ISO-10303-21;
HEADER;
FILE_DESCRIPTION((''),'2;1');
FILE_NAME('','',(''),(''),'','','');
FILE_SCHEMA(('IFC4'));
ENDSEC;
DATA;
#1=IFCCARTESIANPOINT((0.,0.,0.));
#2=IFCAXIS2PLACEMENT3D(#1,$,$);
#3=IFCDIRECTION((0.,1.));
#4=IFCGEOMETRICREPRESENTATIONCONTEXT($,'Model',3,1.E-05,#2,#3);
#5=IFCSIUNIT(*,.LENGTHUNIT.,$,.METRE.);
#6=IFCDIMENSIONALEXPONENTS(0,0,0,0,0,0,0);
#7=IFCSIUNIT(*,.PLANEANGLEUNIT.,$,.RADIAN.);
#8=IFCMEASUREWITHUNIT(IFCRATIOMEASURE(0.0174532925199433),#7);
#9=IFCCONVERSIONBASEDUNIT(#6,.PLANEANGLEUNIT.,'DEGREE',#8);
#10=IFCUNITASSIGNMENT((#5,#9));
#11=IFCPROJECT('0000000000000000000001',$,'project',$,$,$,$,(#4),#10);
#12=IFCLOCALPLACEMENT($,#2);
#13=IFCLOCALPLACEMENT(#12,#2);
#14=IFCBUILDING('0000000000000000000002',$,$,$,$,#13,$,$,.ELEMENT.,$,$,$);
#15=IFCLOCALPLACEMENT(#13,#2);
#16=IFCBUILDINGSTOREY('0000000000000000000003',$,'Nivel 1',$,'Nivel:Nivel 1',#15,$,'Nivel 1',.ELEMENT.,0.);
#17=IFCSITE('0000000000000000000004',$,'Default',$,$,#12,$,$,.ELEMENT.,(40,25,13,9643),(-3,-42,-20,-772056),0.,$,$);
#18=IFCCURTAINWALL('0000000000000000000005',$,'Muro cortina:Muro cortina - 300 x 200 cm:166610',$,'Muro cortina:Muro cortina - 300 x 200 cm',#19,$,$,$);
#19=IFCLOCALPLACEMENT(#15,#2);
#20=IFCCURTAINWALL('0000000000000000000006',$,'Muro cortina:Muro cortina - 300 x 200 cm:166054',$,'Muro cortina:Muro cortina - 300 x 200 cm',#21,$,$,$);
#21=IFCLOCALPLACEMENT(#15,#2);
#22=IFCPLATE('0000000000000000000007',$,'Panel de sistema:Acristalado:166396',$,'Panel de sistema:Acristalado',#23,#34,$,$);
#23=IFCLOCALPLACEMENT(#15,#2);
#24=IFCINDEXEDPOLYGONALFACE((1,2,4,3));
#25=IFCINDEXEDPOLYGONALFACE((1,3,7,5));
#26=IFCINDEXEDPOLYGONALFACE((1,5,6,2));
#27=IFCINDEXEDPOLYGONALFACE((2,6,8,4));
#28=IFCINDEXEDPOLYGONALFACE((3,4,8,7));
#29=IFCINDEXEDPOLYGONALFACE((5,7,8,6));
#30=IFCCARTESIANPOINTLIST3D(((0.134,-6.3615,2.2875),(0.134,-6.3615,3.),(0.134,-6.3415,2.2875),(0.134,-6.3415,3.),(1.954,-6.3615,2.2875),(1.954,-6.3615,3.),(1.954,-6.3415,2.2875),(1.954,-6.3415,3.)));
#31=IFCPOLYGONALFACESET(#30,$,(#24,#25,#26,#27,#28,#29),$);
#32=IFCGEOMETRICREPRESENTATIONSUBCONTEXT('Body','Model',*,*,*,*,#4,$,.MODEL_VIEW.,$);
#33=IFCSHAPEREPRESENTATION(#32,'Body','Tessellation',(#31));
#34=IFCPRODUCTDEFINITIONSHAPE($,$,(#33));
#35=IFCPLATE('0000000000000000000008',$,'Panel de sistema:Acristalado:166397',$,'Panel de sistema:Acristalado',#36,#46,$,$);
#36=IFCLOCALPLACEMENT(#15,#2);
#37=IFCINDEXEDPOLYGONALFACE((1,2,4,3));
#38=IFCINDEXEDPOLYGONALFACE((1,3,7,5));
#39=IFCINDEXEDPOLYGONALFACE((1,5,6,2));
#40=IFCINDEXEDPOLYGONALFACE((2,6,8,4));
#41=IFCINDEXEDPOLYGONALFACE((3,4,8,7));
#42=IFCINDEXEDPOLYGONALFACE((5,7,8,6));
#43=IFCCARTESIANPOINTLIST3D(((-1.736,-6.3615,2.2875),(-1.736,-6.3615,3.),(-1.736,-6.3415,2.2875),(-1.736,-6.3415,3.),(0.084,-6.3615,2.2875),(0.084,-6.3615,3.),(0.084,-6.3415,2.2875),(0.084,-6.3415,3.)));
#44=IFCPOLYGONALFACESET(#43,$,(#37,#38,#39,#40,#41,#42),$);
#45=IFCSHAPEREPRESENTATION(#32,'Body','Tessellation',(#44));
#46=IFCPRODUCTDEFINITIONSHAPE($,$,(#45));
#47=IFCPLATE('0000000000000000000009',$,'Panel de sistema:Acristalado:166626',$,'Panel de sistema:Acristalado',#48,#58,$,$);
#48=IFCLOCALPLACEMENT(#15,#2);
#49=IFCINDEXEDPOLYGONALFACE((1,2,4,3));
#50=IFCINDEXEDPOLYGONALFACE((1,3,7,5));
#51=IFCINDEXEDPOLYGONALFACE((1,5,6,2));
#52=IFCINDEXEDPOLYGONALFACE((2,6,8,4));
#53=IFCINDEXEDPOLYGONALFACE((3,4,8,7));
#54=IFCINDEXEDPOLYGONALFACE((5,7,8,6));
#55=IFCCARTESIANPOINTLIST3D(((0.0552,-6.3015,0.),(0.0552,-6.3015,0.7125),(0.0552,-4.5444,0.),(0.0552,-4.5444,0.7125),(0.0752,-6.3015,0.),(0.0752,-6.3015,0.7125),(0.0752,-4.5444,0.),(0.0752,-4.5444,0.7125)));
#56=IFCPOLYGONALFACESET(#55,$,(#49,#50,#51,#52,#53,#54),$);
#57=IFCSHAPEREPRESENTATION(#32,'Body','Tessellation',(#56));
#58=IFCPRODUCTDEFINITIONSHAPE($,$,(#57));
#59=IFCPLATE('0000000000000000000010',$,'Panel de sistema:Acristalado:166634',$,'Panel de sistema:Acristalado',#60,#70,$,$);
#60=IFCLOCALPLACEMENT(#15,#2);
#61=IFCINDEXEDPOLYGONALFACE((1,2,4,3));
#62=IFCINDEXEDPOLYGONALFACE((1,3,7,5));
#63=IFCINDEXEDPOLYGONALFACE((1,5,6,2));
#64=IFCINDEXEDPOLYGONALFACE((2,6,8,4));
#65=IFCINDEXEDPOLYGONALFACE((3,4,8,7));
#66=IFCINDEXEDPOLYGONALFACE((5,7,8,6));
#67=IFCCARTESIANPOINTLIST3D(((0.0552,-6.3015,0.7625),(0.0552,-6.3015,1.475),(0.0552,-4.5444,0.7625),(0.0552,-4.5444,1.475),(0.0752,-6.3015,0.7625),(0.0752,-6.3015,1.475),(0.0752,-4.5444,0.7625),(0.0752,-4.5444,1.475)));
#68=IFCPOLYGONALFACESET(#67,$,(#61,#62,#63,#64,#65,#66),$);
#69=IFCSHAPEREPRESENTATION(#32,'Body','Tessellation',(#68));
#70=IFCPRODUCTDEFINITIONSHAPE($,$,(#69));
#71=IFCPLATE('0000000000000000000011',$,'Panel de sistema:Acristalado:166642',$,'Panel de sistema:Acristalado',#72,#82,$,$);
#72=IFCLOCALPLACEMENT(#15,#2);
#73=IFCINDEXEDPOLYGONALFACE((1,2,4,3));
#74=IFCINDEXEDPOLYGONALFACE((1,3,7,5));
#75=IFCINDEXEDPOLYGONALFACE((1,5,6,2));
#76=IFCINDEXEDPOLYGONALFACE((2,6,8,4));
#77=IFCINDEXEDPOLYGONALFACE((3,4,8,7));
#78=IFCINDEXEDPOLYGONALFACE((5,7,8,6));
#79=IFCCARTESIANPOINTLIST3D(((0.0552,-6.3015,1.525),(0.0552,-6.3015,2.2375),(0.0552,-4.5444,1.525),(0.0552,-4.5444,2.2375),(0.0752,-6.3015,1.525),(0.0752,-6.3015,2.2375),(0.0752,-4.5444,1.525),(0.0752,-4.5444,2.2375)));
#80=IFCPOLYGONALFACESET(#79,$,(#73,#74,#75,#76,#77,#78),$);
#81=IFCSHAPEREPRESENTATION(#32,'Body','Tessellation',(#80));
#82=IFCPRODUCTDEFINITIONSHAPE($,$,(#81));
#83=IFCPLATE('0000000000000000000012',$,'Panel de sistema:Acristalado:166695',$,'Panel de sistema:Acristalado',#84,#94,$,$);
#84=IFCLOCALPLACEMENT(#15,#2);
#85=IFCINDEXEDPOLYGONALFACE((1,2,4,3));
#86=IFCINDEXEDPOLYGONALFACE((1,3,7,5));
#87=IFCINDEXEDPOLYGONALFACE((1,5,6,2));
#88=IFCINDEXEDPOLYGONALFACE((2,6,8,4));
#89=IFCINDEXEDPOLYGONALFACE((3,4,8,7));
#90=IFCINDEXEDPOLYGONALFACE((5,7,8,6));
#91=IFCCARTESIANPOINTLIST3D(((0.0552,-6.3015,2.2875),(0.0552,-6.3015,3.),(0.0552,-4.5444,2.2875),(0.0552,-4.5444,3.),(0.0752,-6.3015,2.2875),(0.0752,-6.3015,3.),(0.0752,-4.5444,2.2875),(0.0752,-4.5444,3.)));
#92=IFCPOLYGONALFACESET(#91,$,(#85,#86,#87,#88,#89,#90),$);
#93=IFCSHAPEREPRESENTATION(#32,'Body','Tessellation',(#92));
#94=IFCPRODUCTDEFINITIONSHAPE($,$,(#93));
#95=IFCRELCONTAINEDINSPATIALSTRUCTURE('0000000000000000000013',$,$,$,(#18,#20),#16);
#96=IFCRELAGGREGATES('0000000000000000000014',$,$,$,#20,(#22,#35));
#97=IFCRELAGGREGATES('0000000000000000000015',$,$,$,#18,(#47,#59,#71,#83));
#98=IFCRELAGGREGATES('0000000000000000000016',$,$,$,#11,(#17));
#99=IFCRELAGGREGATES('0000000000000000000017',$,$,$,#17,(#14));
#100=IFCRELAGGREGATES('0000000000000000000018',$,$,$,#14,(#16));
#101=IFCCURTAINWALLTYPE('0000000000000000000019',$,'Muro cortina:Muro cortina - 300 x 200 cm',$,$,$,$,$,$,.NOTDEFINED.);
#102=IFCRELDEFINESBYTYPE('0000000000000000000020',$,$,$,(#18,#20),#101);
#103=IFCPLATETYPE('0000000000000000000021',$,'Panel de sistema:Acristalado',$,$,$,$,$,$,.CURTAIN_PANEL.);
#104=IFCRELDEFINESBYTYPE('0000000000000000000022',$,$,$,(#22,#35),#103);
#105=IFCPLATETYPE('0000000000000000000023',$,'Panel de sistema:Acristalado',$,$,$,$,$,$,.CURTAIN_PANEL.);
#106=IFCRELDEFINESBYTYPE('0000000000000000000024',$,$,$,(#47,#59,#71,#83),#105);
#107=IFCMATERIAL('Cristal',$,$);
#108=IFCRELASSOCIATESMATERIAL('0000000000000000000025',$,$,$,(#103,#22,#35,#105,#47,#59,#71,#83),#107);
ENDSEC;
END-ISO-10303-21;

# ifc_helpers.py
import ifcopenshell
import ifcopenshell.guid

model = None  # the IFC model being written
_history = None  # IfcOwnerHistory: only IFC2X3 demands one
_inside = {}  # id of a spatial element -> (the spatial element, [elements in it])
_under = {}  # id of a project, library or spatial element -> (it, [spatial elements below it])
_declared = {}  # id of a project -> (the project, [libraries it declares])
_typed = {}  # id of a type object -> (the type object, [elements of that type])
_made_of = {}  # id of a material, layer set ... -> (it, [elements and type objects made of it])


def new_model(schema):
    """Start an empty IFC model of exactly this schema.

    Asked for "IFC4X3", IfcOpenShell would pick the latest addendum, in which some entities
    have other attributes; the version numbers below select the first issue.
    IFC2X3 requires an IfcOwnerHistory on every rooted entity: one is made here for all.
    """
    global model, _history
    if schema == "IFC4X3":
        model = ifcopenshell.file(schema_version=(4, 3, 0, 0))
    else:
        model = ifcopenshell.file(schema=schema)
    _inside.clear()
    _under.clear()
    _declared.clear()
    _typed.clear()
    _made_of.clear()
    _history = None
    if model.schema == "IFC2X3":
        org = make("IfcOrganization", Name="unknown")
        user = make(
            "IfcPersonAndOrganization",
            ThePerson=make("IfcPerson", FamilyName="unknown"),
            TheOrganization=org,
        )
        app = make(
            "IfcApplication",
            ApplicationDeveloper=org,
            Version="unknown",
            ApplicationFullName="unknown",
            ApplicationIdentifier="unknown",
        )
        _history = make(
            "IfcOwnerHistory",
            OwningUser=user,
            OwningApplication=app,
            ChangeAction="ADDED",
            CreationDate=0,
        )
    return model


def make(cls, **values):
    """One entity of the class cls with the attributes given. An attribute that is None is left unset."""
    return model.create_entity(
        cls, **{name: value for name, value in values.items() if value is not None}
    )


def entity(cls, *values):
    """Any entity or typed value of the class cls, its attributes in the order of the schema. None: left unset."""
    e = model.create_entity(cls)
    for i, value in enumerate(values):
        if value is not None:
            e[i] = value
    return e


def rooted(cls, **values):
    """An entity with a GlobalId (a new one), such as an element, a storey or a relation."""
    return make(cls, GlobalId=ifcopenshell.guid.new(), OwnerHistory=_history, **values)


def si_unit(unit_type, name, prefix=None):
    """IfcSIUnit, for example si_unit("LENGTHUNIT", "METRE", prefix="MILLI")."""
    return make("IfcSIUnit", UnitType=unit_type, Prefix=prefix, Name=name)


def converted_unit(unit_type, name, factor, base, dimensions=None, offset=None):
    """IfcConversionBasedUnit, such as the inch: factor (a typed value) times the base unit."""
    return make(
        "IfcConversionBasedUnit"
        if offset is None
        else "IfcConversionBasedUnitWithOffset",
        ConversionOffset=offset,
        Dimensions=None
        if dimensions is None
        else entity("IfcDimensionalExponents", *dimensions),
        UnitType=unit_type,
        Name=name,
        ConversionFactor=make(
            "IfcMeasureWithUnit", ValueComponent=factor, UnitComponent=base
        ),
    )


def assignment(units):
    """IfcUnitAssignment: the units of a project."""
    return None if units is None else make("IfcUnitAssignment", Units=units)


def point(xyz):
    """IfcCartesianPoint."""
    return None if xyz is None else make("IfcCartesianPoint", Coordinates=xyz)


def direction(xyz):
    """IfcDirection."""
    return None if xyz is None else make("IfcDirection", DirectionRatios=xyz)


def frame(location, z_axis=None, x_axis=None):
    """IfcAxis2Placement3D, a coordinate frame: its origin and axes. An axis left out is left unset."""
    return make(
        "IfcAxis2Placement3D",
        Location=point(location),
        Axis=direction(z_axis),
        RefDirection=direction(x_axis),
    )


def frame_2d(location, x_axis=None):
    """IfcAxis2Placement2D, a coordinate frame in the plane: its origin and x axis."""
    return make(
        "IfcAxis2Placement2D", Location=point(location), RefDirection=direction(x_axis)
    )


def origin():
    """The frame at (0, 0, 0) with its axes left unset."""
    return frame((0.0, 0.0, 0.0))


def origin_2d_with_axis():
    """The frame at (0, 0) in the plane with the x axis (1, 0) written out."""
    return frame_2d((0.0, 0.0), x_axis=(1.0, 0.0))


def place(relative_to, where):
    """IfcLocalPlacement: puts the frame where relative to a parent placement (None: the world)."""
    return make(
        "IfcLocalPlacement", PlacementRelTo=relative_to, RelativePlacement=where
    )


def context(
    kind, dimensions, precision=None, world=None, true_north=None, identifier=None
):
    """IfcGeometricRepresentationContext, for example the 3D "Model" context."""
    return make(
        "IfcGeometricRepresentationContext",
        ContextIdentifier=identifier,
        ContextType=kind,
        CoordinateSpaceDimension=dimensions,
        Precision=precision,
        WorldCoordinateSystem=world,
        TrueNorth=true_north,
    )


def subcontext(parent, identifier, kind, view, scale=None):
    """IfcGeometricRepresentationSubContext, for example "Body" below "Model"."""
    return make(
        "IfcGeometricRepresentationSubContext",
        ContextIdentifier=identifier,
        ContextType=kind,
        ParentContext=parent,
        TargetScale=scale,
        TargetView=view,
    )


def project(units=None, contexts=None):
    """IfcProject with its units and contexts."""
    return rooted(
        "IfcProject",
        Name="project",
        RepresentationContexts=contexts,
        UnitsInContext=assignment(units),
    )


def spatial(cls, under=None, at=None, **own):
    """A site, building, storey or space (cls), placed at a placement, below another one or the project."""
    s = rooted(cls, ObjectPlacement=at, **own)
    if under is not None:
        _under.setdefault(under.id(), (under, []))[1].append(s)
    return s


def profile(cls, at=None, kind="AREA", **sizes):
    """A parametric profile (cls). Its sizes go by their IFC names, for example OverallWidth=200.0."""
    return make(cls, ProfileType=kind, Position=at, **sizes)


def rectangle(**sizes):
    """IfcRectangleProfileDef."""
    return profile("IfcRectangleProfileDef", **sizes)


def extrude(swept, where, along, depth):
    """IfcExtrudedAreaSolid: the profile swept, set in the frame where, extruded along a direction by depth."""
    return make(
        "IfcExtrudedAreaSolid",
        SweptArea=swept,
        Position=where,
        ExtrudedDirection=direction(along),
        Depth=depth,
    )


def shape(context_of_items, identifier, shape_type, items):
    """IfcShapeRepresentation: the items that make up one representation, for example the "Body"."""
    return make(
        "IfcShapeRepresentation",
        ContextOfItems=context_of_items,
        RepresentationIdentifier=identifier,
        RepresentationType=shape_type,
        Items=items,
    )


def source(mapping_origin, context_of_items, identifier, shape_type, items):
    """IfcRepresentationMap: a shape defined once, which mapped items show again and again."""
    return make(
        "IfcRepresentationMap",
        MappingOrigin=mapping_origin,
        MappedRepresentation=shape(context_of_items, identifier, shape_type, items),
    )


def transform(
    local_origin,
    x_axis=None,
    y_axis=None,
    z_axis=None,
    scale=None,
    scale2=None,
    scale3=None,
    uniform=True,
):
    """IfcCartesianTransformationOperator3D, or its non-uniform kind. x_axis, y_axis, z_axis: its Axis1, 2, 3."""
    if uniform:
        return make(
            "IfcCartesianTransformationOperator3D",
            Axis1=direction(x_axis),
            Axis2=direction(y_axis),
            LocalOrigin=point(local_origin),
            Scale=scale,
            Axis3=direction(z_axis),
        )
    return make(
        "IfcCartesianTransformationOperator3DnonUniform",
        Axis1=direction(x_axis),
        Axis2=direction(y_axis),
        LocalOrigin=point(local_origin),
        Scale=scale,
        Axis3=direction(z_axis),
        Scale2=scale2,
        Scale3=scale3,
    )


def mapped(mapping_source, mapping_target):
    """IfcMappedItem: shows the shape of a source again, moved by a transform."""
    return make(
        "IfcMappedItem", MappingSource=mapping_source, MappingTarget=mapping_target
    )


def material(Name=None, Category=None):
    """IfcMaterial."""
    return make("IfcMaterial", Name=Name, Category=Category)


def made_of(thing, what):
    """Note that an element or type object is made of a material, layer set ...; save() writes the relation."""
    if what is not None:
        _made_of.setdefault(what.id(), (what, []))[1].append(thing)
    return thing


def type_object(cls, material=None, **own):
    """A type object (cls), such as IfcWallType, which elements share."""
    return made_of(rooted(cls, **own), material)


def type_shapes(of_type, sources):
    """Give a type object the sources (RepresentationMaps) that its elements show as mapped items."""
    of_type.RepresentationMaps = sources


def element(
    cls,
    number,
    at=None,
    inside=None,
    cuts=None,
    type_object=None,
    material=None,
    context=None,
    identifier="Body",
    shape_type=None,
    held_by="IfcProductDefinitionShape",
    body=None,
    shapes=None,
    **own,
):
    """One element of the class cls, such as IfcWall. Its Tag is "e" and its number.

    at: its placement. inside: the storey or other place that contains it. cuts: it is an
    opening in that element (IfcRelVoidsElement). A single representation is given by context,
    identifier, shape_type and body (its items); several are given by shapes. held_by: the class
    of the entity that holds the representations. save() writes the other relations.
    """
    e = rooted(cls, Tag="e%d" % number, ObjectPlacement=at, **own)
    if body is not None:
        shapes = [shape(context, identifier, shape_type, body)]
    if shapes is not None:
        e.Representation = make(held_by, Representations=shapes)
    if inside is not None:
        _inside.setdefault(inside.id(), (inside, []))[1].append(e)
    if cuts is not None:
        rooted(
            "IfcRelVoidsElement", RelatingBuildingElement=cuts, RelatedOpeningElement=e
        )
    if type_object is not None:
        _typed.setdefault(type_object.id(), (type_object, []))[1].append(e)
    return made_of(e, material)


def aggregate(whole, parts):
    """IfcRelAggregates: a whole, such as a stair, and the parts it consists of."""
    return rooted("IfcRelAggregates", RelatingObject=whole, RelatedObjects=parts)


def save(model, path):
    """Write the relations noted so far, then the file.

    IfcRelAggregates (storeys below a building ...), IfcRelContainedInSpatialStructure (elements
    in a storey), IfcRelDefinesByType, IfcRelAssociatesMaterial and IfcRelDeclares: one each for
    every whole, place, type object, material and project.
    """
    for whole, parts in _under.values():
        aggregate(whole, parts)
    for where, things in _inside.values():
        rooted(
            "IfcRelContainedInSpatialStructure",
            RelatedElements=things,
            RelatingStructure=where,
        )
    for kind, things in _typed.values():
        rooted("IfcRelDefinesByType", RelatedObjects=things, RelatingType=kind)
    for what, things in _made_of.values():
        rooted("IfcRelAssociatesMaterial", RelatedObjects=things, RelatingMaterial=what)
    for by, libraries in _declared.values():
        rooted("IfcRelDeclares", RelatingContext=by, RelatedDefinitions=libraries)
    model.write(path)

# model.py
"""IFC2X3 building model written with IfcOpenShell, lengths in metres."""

from ifc_helpers import new_model, entity, si_unit, converted_unit, direction, frame, origin, origin_2d_with_axis, place, context, subcontext, project, spatial, rectangle, extrude, source, transform, mapped, material, type_object, type_shapes, element, aggregate, save


model = new_model("IFC2X3")

# Units and contexts
model_context = context("Model", 3, precision=1e-05, world=origin(), true_north=direction((0.0, 1.0)))
body_context = subcontext(model_context, "Body", "Model", "MODEL_VIEW")
ifc_project = project(units=[si_unit("LENGTHUNIT", "METRE"), converted_unit("PLANEANGLEUNIT", "DEGREE", entity("IfcRatioMeasure", 0.0174532925199433), si_unit("PLANEANGLEUNIT", "RADIAN"), dimensions=[0, 0, 0, 0, 0, 0, 0])], contexts=[model_context])

# Site, building, storey
site_placement = place(None, origin())
site = spatial("IfcSite", under=ifc_project, at=site_placement, Name="Default", CompositionType="ELEMENT", RefLatitude=(40, 25, 13, 9643), RefLongitude=(-3, -42, -20, -772056), RefElevation=0.0)
building_placement = place(site_placement, origin())
building = spatial("IfcBuilding", under=site, at=building_placement, CompositionType="ELEMENT")
storey_placement = place(building_placement, origin())
storey = spatial("IfcBuildingStorey", under=building, at=storey_placement, Name="Nivel 1", ObjectType="Nivel:Nivel 1", LongName="Nivel 1", CompositionType="ELEMENT", Elevation=0.0)

# Curtain walls
curtain_wall_type = type_object("IfcCurtainWallType", Name="Muro cortina:Muro cortina - 300 x 200 cm", PredefinedType="NOTDEFINED")
curtain_wall_1_placement = place(storey_placement, origin())
curtain_wall_1 = element("IfcCurtainWall", 1, at=curtain_wall_1_placement, inside=storey, type_object=curtain_wall_type, Name="Muro cortina:Muro cortina - 300 x 200 cm:166610", ObjectType="Muro cortina:Muro cortina - 300 x 200 cm")
curtain_wall_2_placement = place(storey_placement, origin())
curtain_wall_2 = element("IfcCurtainWall", 2, at=curtain_wall_2_placement, inside=storey, type_object=curtain_wall_type, Name="Muro cortina:Muro cortina - 300 x 200 cm:166054", ObjectType="Muro cortina:Muro cortina - 300 x 200 cm")

# Plates
ifc_material_1 = material(Name="Cristal")
plate_type_1 = type_object("IfcPlateType", Name="Panel de sistema:Acristalado", PredefinedType="CURTAIN_PANEL", material=ifc_material_1)
shared_shape_1 = source(origin(), body_context, "Body", "SweptSolid", [
    extrude(rectangle(XDim=0.02, YDim=1.82, at=origin_2d_with_axis()), frame((0.0, 0.0, 0.0), z_axis=(0.0, 0.0, 1.0), x_axis=(0.0, 1.0, 0.0)), (0.0, 0.0, 1.0), 0.7125),
])
type_shapes(plate_type_1, [shared_shape_1])
plate_1_placement = place(curtain_wall_2_placement, frame((1.044, -6.3515, 2.2875), z_axis=(0.0, 0.0, 1.0), x_axis=(-1.0, 0.0, 0.0)))
plate_1 = element("IfcPlate", 3, at=plate_1_placement, type_object=plate_type_1, material=ifc_material_1, Name="Panel de sistema:Acristalado:166396", ObjectType="Panel de sistema:Acristalado", context=body_context, shape_type="MappedRepresentation", body=[
    mapped(shared_shape_1, transform((0.0, 0.0, 0.0), scale=1.0)),
])
plate_2_placement = place(curtain_wall_2_placement, frame((-0.826, -6.3515, 2.2875), z_axis=(0.0, 0.0, 1.0), x_axis=(-1.0, 0.0, 0.0)))
plate_2 = element("IfcPlate", 4, at=plate_2_placement, type_object=plate_type_1, material=ifc_material_1, Name="Panel de sistema:Acristalado:166397", ObjectType="Panel de sistema:Acristalado", context=body_context, shape_type="MappedRepresentation", body=[
    mapped(shared_shape_1, transform((0.0, 0.0, 0.0), scale=1.0)),
])
aggregate(curtain_wall_2, [plate_1, plate_2])
plate_type_2 = type_object("IfcPlateType", Name="Panel de sistema:Acristalado", PredefinedType="CURTAIN_PANEL", material=ifc_material_1)
shared_shape_2 = source(origin(), body_context, "Body", "SweptSolid", [
    extrude(rectangle(XDim=0.02, YDim=1.7571, at=origin_2d_with_axis()), frame((0.0, 0.0, 0.0), z_axis=(0.0, 0.0, 1.0), x_axis=(0.0, 1.0, 0.0)), (0.0, 0.0, 1.0), 0.7125),
])
type_shapes(plate_type_2, [shared_shape_2])
plate_3_placement = place(curtain_wall_1_placement, frame((0.0652, -5.423, 0.0), z_axis=(0.0, 0.0, 1.0), x_axis=(0.0, -1.0, 0.0)))
plate_3 = element("IfcPlate", 5, at=plate_3_placement, type_object=plate_type_2, material=ifc_material_1, Name="Panel de sistema:Acristalado:166626", ObjectType="Panel de sistema:Acristalado", context=body_context, shape_type="MappedRepresentation", body=[
    mapped(shared_shape_2, transform((0.0, 0.0, 0.0), scale=1.0)),
])
plate_4_placement = place(curtain_wall_1_placement, frame((0.0652, -5.423, 0.7625), z_axis=(0.0, 0.0, 1.0), x_axis=(0.0, -1.0, 0.0)))
plate_4 = element("IfcPlate", 6, at=plate_4_placement, type_object=plate_type_2, material=ifc_material_1, Name="Panel de sistema:Acristalado:166634", ObjectType="Panel de sistema:Acristalado", context=body_context, shape_type="MappedRepresentation", body=[
    mapped(shared_shape_2, transform((0.0, 0.0, 0.0), scale=1.0)),
])
plate_5_placement = place(curtain_wall_1_placement, frame((0.0652, -5.423, 1.525), z_axis=(0.0, 0.0, 1.0), x_axis=(0.0, -1.0, 0.0)))
plate_5 = element("IfcPlate", 7, at=plate_5_placement, type_object=plate_type_2, material=ifc_material_1, Name="Panel de sistema:Acristalado:166642", ObjectType="Panel de sistema:Acristalado", context=body_context, shape_type="MappedRepresentation", body=[
    mapped(shared_shape_2, transform((0.0, 0.0, 0.0), scale=1.0)),
])
plate_6_placement = place(curtain_wall_1_placement, frame((0.0652, -5.423, 2.2875), z_axis=(0.0, 0.0, 1.0), x_axis=(0.0, -1.0, 0.0)))
plate_6 = element("IfcPlate", 8, at=plate_6_placement, type_object=plate_type_2, material=ifc_material_1, Name="Panel de sistema:Acristalado:166695", ObjectType="Panel de sistema:Acristalado", context=body_context, shape_type="MappedRepresentation", body=[
    mapped(shared_shape_2, transform((0.0, 0.0, 0.0), scale=1.0)),
])
aggregate(curtain_wall_1, [plate_3, plate_4, plate_5, plate_6])

save(model, "model.ifc")
